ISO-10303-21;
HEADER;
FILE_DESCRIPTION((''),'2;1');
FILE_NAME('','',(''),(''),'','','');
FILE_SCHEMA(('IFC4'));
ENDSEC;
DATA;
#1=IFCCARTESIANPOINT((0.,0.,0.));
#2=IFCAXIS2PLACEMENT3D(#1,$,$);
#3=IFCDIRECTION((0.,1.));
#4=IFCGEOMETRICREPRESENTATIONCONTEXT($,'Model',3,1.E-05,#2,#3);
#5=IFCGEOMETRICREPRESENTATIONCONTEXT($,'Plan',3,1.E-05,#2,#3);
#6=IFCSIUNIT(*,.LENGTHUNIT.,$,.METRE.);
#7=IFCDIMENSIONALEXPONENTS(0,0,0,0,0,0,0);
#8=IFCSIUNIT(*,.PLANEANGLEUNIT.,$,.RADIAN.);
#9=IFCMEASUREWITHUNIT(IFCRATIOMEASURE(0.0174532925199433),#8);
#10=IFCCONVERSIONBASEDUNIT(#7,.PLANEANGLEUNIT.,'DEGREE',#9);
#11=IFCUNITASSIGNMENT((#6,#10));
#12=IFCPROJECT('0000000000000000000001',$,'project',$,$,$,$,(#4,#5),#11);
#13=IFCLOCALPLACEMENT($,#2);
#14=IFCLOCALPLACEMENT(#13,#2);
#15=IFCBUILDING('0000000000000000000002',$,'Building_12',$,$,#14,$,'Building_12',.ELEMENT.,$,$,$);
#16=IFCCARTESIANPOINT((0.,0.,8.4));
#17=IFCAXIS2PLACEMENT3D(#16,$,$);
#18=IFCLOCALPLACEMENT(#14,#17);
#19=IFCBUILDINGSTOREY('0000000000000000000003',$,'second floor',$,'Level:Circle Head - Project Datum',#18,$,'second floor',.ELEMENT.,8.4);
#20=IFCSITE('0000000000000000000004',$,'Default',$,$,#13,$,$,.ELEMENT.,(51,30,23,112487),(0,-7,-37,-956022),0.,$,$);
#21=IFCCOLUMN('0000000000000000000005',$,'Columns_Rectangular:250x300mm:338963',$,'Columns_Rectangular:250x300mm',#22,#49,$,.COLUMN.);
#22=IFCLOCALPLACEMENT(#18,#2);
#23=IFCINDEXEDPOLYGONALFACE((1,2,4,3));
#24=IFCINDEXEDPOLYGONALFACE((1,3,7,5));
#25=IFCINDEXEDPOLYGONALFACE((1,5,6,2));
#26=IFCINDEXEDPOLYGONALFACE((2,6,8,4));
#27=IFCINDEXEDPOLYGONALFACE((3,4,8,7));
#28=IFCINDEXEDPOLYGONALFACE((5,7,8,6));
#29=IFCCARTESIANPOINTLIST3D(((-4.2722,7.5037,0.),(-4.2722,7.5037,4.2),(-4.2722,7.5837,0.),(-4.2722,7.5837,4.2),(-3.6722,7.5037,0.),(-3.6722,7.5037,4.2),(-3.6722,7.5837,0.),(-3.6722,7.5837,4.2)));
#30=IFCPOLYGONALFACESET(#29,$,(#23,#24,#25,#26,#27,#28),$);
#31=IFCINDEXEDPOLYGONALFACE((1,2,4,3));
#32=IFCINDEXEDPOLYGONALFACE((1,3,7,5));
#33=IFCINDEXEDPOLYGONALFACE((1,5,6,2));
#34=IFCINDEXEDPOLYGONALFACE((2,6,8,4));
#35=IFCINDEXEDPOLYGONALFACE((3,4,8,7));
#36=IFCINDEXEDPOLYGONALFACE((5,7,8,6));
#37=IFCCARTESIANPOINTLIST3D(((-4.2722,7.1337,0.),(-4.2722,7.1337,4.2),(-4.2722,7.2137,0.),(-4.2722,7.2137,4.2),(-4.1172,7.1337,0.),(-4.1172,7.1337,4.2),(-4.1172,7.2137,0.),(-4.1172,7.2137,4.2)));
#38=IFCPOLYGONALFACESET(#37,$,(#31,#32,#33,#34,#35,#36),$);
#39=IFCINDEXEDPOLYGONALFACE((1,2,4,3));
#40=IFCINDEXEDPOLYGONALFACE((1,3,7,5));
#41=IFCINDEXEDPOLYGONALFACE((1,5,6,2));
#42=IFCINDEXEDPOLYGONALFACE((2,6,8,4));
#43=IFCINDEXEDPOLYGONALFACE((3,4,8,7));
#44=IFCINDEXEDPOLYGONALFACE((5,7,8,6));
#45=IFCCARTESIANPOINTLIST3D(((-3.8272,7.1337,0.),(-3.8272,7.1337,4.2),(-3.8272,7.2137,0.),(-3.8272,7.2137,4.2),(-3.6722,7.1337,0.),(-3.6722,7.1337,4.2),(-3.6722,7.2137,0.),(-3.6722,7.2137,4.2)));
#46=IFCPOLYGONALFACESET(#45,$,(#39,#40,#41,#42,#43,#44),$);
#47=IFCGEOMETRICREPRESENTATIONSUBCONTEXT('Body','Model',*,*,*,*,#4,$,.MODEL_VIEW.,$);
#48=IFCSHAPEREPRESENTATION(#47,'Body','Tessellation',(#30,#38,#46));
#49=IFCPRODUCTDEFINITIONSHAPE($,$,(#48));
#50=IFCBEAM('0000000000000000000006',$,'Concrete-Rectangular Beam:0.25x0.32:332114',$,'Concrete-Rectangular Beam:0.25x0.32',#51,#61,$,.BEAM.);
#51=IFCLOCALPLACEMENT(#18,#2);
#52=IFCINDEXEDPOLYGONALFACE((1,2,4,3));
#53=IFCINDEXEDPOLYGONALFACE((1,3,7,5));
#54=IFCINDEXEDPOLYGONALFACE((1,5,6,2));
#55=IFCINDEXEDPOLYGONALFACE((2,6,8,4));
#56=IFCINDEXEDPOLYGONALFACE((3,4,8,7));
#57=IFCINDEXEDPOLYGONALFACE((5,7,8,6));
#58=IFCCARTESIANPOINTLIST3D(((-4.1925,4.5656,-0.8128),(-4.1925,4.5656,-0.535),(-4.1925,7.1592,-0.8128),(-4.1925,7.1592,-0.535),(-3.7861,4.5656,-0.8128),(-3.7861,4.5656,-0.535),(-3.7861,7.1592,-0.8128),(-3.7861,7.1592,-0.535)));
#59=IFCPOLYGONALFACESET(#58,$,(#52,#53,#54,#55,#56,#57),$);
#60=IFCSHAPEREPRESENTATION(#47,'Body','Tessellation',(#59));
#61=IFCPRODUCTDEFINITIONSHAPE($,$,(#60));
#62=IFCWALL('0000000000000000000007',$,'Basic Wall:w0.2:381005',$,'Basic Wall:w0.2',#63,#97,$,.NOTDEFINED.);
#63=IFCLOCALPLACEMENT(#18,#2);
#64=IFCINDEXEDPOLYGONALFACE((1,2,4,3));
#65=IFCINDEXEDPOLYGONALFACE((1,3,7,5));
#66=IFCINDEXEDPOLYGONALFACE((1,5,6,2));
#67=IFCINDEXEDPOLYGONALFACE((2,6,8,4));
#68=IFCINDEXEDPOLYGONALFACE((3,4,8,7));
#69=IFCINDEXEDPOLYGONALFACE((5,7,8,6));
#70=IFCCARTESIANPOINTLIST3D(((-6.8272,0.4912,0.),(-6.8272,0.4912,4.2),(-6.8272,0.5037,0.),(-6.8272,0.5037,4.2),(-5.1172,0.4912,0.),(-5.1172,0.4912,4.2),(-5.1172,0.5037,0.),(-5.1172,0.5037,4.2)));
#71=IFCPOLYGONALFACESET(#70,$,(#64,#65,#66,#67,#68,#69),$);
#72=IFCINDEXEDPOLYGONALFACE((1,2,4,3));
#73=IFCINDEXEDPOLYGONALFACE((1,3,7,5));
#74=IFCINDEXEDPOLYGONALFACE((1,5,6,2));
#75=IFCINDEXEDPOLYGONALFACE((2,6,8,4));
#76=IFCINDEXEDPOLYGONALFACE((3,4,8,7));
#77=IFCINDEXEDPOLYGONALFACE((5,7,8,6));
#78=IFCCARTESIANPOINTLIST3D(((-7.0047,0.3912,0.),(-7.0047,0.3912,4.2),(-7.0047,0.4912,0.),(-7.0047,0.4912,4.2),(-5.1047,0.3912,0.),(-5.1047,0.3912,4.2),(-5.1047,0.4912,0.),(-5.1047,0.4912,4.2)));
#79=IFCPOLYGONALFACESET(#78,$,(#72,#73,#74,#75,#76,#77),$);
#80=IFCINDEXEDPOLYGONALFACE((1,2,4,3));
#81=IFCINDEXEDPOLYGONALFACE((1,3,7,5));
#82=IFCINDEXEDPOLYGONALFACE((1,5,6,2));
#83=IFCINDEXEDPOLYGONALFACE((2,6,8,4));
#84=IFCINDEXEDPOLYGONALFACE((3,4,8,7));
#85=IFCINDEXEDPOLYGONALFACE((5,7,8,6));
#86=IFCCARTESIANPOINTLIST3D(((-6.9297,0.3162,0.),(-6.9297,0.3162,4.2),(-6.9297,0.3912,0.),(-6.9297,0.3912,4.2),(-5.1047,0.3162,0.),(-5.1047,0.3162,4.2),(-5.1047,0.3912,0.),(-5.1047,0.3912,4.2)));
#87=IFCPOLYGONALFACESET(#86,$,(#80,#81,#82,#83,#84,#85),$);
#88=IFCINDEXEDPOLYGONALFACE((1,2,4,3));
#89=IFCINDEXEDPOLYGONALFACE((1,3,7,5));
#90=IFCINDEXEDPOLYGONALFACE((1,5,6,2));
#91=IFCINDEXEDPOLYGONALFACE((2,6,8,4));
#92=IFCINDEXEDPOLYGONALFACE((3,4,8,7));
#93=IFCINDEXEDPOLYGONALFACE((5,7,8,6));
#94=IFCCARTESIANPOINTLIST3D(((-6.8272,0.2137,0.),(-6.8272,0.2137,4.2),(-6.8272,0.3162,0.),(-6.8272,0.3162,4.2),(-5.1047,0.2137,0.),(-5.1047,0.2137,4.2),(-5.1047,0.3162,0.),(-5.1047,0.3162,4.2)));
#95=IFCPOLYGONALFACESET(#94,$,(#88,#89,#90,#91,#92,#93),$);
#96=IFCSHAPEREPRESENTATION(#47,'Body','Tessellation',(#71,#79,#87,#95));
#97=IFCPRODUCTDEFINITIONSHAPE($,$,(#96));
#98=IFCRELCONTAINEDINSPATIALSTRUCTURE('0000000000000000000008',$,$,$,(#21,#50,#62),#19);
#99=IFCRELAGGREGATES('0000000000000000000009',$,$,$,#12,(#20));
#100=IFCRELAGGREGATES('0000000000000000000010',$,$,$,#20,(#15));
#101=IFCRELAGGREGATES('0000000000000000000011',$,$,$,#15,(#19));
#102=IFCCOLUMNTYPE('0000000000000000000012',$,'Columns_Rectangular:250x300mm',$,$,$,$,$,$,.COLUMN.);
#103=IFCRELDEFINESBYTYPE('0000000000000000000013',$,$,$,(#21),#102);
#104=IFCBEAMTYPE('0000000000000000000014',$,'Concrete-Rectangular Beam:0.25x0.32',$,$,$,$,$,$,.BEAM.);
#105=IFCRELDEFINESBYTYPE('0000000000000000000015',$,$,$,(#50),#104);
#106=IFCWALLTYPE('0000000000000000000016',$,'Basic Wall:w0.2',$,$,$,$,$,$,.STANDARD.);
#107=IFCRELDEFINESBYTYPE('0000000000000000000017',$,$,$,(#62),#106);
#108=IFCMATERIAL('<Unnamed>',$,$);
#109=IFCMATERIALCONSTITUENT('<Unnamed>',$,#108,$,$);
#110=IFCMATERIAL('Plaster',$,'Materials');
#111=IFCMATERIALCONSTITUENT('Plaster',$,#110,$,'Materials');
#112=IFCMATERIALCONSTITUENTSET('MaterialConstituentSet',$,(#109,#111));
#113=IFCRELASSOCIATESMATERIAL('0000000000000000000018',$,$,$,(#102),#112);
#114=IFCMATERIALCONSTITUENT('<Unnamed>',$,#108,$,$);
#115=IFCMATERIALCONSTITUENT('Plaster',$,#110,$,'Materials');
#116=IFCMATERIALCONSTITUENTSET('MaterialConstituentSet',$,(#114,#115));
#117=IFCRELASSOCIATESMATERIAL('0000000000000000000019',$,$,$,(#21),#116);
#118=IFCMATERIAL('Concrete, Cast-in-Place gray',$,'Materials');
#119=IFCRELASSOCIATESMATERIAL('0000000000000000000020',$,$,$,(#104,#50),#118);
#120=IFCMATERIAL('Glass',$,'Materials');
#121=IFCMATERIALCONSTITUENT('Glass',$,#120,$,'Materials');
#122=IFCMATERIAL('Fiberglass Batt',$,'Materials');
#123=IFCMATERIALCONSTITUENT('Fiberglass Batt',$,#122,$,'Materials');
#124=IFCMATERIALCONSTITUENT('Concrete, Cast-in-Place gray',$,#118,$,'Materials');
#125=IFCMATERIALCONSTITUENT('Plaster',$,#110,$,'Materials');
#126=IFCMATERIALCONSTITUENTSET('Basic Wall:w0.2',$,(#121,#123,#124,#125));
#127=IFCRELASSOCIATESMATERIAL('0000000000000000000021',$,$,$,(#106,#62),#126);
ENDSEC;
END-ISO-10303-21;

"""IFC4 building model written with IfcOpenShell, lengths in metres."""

from ifc_helpers import new_model, entity, si_unit, converted_unit, direction, frame, origin, place, context, subcontext, project, spatial, indexed_curve, outline, extrude, source, transform, mapped, material, constituent, constituent_set, type_object, type_shapes, element, save


model = new_model("IFC4")

# Units and contexts
model_context = context("Model", 3, precision=1e-05, world=origin(), true_north=direction((0.0, 1.0)))
plan_context = context("Plan", 3, precision=1e-05, world=origin(), true_north=direction((0.0, 1.0)))
body_context = subcontext(model_context, "Body", "Model", "MODEL_VIEW")
ifc_project = project(units=[si_unit("LENGTHUNIT", "METRE"), converted_unit("PLANEANGLEUNIT", "DEGREE", entity("IfcRatioMeasure", 0.0174532925199433), si_unit("PLANEANGLEUNIT", "RADIAN"), dimensions=[0, 0, 0, 0, 0, 0, 0])], contexts=[model_context, plan_context])

# Site, building, storey
site_placement = place(None, origin())
site = spatial("IfcSite", under=ifc_project, at=site_placement, Name="Default", CompositionType="ELEMENT", RefLatitude=(51, 30, 23, 112487), RefLongitude=(0, -7, -37, -956022), RefElevation=0.0)
building_placement = place(site_placement, origin())
building = spatial("IfcBuilding", under=site, at=building_placement, Name="Building_12", LongName="Building_12", CompositionType="ELEMENT")
storey_placement = place(building_placement, frame((0.0, 0.0, 8.4)))
storey = spatial("IfcBuildingStorey", under=building, at=storey_placement, Name="second floor", ObjectType="Level:Circle Head - Project Datum", LongName="second floor", CompositionType="ELEMENT", Elevation=8.4)

# Column
ifc_material_1 = material(Name="<Unnamed>")
ifc_material_2 = material(Name="Plaster", Category="Materials")
ifc_constituent_1 = constituent(ifc_material_1, Name="<Unnamed>")
ifc_constituent_2 = constituent(ifc_material_2, Name="Plaster", Category="Materials")
ifc_constituent_set_1 = constituent_set(constituents=[ifc_constituent_1, ifc_constituent_2], Name="MaterialConstituentSet")
ifc_constituent_3 = constituent(ifc_material_1, Name="<Unnamed>")
ifc_constituent_4 = constituent(ifc_material_2, Name="Plaster", Category="Materials")
ifc_constituent_set_2 = constituent_set(constituents=[ifc_constituent_3, ifc_constituent_4], Name="MaterialConstituentSet")
column_type_1 = type_object("IfcColumnType", Name="Columns_Rectangular:250x300mm", PredefinedType="COLUMN", material=ifc_constituent_set_2)
shared_shape_1 = source(origin(), body_context, "Body", "SweptSolid", [
    extrude(outline(indexed_curve([(-0.04, -0.3), (0.04, -0.3), (0.04, 0.3), (-0.04, 0.3), (-0.04, -0.3)], self_intersect=False)), frame((-3.9722, 7.5437, 8.4), z_axis=(0.0, 0.0, 1.0), x_axis=(0.0, -1.0, 0.0)), (0.0, 0.0, 1.0), 4.2),
    extrude(outline(indexed_curve([(-0.04, -0.0775), (0.04, -0.0775), (0.04, 0.0775), (-0.04, 0.0775), (-0.04, -0.0775)], self_intersect=False)), frame((-4.1947, 7.1737, 8.4), z_axis=(0.0, 0.0, 1.0), x_axis=(0.0, -1.0, 0.0)), (0.0, 0.0, 1.0), 4.2),
    extrude(outline(indexed_curve([(-0.04, -0.0775), (0.04, -0.0775), (0.04, 0.0775), (-0.04, 0.0775), (-0.04, -0.0775)], self_intersect=False)), frame((-3.7497, 7.1737, 8.4), z_axis=(0.0, 0.0, 1.0), x_axis=(0.0, -1.0, 0.0)), (0.0, 0.0, 1.0), 4.2),
])
type_shapes(column_type_1, [shared_shape_1])
column_1_placement = place(storey_placement, frame((0.0, 0.0, -8.4)))
element("IfcColumn", 1, at=column_1_placement, inside=storey, type_object=column_type_1, material=ifc_constituent_set_1, Name="Columns_Rectangular:250x300mm:338963", ObjectType="Columns_Rectangular:250x300mm", PredefinedType="COLUMN", context=body_context, shape_type="MappedRepresentation", body=[
    mapped(shared_shape_1, transform((0.0, 0.0, 0.0), scale=1.0)),
])

# Beam
ifc_material_3 = material(Name="Concrete, Cast-in-Place gray", Category="Materials")
beam_type_1 = type_object("IfcBeamType", Name="Concrete-Rectangular Beam:0.25x0.32", PredefinedType="BEAM", material=ifc_material_3)
shared_shape_2 = source(origin(), body_context, "Body", "SweptSolid", [
    extrude(outline(indexed_curve([(-0.2032, -0.1389), (0.2032, -0.1389), (0.2032, 0.1389), (-0.2032, 0.1389), (-0.2032, -0.1389)], self_intersect=False)), frame((-3.9893, 7.1592, 7.7261), z_axis=(0.0, -1.0, 0.0), x_axis=(-1.0, 0.0, 0.0)), (0.0, 0.0, 1.0), 2.5936),
])
type_shapes(beam_type_1, [shared_shape_2])
beam_1_placement = place(storey_placement, frame((0.0, 0.0, -8.4)))
element("IfcBeam", 2, at=beam_1_placement, inside=storey, type_object=beam_type_1, material=ifc_material_3, Name="Concrete-Rectangular Beam:0.25x0.32:332114", ObjectType="Concrete-Rectangular Beam:0.25x0.32", PredefinedType="BEAM", context=body_context, shape_type="MappedRepresentation", body=[
    mapped(shared_shape_2, transform((0.0, 0.0, 0.0), scale=1.0)),
])

# Shared definitions
ifc_material_4 = material(Name="Glass", Category="Materials")
ifc_constituent_5 = constituent(ifc_material_4, Name="Glass", Category="Materials")
ifc_material_5 = material(Name="Fiberglass Batt", Category="Materials")
ifc_constituent_6 = constituent(ifc_material_5, Name="Fiberglass Batt", Category="Materials")
ifc_constituent_7 = constituent(ifc_material_3, Name="Concrete, Cast-in-Place gray", Category="Materials")
ifc_constituent_8 = constituent(ifc_material_2, Name="Plaster", Category="Materials")
ifc_constituent_set_3 = constituent_set(constituents=[ifc_constituent_5, ifc_constituent_6, ifc_constituent_7, ifc_constituent_8], Name="Basic Wall:w0.2")
wall_type = type_object("IfcWallType", Name="Basic Wall:w0.2", PredefinedType="STANDARD", material=ifc_constituent_set_3)

# Wall
wall_1_placement = place(storey_placement, frame((-5.1172, 0.3587, 0.0), z_axis=(0.0, 0.0, 1.0), x_axis=(-1.0, 0.0, 0.0)))
element("IfcWall", 3, at=wall_1_placement, inside=storey, type_object=wall_type, material=ifc_constituent_set_3, Name="Basic Wall:w0.2:381005", ObjectType="Basic Wall:w0.2", PredefinedType="NOTDEFINED", context=body_context, shape_type="SweptSolid", body=[
    extrude(outline(indexed_curve([(-0.0063, -0.855), (0.0062, -0.855), (0.0063, 0.855), (-0.0062, 0.855), (-0.0063, -0.855)], self_intersect=False)), frame((0.855, -0.1388, 0.0), z_axis=(0.0, 0.0, 1.0), x_axis=(0.0, 1.0, 0.0)), (0.0, 0.0, 1.0), 4.2),
    extrude(outline(indexed_curve([(-0.95, -0.05), (0.95, -0.05), (0.95, 0.05), (-0.95, 0.05), (-0.95, -0.05)], self_intersect=False)), frame((0.9375, -0.0825, 0.0)), (0.0, 0.0, 1.0), 4.2),
    extrude(outline(indexed_curve([(-0.9125, -0.0375), (0.9125, -0.0375), (0.9125, 0.0375), (-0.9125, 0.0375), (-0.9125, -0.0375)], self_intersect=False)), frame((0.9, 0.005, 0.0)), (0.0, 0.0, 1.0), 4.2),
    extrude(outline(indexed_curve([(-0.0513, -0.8613), (0.0512, -0.8613), (0.0513, 0.8612), (-0.0512, 0.8612), (-0.0513, -0.8613)], self_intersect=False)), frame((0.8488, 0.0937, 0.0), z_axis=(0.0, 0.0, 1.0), x_axis=(0.0, -1.0, 0.0)), (0.0, 0.0, 1.0), 4.2),
])

save(model, "model.ifc")
